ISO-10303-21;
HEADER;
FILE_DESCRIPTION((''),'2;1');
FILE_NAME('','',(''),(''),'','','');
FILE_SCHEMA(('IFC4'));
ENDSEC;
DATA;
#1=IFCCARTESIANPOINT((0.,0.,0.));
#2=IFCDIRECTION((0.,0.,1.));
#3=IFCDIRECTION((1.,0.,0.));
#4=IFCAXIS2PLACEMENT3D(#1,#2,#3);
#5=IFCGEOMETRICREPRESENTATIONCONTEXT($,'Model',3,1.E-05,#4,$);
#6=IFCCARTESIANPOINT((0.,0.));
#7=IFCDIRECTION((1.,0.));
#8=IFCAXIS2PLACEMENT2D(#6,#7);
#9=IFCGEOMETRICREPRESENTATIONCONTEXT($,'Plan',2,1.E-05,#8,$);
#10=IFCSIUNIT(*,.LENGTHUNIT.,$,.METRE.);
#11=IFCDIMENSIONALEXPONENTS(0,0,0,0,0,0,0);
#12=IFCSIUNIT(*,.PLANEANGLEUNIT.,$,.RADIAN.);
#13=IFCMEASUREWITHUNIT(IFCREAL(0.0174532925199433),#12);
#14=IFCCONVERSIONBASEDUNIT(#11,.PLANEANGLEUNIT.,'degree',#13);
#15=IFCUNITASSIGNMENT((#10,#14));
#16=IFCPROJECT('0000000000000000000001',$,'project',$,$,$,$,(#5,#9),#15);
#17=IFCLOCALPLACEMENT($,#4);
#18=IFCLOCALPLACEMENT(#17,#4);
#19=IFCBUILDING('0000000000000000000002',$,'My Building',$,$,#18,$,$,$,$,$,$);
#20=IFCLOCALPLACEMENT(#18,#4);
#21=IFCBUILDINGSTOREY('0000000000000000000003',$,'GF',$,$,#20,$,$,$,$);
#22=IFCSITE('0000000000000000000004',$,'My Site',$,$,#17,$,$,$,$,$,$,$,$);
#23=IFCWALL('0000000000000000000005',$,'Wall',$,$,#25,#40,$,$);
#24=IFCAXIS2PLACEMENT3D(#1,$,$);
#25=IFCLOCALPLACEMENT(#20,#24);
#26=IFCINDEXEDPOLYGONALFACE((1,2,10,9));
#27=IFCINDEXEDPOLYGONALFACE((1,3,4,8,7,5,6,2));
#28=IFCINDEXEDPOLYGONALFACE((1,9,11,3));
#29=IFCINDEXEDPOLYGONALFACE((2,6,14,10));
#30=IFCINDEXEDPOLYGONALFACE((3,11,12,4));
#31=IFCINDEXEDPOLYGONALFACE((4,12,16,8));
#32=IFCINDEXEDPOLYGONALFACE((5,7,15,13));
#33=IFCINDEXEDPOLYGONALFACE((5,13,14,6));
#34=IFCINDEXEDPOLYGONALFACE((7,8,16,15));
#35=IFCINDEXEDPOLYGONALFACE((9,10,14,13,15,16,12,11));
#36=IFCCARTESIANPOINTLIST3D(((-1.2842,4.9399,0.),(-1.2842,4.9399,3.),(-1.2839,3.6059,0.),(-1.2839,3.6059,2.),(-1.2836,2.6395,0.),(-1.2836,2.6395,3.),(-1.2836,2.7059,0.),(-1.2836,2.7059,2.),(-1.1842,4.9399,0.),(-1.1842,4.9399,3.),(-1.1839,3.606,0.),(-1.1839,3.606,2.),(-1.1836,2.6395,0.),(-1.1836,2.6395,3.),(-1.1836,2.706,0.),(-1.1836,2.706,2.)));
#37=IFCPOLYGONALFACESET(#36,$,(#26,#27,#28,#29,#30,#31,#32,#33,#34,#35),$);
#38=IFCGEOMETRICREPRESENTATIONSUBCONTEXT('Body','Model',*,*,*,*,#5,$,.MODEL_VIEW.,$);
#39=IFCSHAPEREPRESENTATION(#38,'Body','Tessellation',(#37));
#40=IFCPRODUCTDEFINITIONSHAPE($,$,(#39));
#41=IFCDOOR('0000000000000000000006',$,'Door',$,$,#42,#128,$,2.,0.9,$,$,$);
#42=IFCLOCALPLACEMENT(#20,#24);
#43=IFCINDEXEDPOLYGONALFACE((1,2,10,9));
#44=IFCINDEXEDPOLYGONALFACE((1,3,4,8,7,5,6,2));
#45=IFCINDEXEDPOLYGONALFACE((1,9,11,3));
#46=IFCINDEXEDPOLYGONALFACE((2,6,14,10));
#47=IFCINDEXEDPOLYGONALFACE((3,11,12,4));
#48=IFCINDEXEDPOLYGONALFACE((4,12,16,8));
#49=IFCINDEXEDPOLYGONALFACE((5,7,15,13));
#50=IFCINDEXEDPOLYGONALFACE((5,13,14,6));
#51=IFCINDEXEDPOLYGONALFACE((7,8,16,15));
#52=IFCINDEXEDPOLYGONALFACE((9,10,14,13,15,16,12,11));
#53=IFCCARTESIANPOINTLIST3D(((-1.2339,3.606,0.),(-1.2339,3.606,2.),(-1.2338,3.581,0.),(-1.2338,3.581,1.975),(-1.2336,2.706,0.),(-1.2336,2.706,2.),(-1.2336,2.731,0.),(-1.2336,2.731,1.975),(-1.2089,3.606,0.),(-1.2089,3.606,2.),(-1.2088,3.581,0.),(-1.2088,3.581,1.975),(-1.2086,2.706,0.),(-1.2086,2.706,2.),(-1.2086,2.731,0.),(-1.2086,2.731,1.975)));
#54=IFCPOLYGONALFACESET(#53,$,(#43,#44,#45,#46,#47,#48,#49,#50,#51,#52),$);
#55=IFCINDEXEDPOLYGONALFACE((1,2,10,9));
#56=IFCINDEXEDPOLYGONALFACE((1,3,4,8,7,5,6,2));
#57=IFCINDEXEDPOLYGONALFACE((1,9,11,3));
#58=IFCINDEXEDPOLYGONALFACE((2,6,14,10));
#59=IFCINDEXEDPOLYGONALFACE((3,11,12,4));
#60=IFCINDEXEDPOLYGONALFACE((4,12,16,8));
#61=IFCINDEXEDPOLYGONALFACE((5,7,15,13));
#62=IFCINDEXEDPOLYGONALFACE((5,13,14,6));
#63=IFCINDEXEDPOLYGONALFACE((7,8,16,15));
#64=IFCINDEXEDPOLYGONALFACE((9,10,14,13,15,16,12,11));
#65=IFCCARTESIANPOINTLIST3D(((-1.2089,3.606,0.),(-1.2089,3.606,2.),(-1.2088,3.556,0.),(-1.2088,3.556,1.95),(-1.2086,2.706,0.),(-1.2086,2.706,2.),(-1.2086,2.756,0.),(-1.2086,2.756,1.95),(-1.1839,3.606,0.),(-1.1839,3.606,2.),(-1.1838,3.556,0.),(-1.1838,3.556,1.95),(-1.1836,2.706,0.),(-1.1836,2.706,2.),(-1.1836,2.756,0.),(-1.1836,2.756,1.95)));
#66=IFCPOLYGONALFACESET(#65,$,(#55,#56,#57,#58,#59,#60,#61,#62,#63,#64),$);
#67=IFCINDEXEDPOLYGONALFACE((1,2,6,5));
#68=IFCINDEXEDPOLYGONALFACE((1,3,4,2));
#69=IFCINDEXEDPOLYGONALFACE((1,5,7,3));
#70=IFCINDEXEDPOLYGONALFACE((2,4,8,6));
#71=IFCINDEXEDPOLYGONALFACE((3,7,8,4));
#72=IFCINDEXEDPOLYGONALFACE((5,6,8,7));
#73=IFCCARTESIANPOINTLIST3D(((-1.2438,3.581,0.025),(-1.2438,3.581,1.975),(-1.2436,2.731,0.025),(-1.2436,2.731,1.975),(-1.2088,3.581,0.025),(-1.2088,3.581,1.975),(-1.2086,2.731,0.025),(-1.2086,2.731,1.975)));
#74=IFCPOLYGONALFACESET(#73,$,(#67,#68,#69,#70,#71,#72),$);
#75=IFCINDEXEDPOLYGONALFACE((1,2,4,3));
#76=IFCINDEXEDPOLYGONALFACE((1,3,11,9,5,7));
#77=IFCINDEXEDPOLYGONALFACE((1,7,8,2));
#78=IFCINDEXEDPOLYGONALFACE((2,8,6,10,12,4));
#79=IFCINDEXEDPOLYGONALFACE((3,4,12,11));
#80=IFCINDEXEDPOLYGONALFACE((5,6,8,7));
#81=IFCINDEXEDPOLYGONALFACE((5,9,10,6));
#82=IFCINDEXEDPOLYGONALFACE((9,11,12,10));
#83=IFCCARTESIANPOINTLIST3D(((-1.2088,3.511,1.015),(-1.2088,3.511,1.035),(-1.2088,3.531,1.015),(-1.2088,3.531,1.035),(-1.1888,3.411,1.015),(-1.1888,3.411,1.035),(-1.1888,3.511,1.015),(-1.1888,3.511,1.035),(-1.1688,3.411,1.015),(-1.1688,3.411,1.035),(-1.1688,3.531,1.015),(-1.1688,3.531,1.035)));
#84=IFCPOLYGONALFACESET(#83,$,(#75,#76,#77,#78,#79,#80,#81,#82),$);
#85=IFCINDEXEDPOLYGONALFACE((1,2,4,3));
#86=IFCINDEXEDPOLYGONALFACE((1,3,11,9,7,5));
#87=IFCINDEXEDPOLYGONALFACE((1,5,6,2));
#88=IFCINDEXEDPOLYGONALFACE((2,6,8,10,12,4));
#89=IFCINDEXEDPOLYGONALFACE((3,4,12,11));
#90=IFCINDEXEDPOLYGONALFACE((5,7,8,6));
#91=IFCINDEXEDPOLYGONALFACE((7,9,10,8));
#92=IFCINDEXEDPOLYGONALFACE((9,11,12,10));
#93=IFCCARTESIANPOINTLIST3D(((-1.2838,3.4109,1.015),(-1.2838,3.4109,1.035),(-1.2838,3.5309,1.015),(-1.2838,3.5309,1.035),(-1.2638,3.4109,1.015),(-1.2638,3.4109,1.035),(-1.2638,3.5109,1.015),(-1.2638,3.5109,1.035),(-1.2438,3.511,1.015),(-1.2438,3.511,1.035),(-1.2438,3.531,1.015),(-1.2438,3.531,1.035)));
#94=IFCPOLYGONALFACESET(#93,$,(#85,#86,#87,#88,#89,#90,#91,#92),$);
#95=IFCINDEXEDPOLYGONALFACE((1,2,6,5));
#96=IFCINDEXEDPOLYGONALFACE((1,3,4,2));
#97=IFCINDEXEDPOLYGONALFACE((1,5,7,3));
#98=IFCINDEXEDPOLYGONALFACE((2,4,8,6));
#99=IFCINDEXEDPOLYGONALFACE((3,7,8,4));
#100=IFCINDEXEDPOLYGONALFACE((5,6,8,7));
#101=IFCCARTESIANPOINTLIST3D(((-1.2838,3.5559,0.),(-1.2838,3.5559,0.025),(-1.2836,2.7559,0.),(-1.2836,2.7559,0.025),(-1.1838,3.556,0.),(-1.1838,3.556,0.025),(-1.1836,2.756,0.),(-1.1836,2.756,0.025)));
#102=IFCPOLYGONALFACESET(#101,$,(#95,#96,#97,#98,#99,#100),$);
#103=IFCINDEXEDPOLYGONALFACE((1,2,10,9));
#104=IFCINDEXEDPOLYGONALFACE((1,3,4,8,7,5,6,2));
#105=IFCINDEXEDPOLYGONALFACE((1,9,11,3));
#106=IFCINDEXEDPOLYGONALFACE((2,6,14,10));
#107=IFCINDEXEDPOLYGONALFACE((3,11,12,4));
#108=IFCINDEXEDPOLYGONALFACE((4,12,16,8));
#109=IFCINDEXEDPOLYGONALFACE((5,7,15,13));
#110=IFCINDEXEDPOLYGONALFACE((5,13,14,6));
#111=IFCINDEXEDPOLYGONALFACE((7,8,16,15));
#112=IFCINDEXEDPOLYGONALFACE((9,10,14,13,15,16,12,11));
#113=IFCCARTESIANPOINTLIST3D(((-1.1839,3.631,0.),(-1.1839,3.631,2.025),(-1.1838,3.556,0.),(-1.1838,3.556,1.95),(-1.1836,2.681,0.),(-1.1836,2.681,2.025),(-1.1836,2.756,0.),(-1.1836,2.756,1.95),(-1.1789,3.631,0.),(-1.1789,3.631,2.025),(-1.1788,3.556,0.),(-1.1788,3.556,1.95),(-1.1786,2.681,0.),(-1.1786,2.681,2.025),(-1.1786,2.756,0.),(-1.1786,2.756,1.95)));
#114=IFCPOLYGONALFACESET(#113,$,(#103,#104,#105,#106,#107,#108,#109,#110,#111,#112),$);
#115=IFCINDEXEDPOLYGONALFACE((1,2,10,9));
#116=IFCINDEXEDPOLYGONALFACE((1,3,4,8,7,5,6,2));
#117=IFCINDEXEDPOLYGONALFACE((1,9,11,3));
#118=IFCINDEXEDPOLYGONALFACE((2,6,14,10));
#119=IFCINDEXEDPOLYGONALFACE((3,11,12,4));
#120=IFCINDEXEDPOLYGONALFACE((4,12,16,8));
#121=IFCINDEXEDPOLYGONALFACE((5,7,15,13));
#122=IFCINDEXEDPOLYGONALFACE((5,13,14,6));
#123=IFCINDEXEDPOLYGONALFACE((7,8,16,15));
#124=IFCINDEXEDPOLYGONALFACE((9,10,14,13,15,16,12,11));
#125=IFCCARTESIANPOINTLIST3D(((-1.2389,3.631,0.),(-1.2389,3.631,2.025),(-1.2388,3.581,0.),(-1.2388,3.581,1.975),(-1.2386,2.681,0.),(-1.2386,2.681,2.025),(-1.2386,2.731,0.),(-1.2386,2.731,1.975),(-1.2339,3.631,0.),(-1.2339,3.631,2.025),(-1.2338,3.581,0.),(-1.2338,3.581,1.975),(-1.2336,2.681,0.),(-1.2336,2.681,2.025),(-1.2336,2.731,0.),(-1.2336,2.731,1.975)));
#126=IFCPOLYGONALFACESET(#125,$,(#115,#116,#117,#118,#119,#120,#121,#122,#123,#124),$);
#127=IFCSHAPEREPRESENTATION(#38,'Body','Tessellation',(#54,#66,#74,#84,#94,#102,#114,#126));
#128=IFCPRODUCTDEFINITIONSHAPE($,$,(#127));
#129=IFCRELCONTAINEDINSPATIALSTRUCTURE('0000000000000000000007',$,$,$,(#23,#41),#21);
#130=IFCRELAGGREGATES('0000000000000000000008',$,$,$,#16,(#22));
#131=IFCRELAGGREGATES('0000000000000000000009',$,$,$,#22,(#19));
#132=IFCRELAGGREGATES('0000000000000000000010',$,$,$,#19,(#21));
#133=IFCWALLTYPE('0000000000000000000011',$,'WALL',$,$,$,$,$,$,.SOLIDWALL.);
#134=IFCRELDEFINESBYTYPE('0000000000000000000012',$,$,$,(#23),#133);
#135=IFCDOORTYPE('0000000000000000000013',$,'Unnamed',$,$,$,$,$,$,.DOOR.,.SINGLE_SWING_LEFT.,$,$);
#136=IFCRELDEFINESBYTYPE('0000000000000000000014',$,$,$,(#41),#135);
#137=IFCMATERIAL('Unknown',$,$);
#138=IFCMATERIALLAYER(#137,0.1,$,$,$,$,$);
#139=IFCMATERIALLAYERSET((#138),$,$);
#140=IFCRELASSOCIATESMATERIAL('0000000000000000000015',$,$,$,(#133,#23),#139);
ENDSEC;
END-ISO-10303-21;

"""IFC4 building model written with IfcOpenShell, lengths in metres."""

from ifc_helpers import new_model, entity, si_unit, converted_unit, frame, origin_with_axes, origin_2d_with_axis, place, context, subcontext, project, spatial, line, indexed_curve, outline, extrude, shape, source, transform, mapped, material, layer, layer_set, layer_usage, type_object, type_shapes, element, fill, save


model = new_model("IFC4")

# Units and contexts
model_context = context("Model", 3, precision=1e-05, world=origin_with_axes())
plan_context = context("Plan", 2, precision=1e-05, world=origin_2d_with_axis())
body_context_1 = subcontext(model_context, "Body", "Model", "MODEL_VIEW")
body_context_2 = subcontext(plan_context, "Body", "Plan", "PLAN_VIEW")
ifc_project = project(units=[si_unit("LENGTHUNIT", "METRE"), converted_unit("PLANEANGLEUNIT", "degree", entity("IfcReal", 0.0174532925199433), si_unit("PLANEANGLEUNIT", "RADIAN"), dimensions=[0, 0, 0, 0, 0, 0, 0])], contexts=[model_context, plan_context])

# Site, building, storey
site_placement = place(None, origin_with_axes())
site = spatial("IfcSite", under=ifc_project, at=site_placement, Name="My Site")
building_placement = place(site_placement, origin_with_axes())
building = spatial("IfcBuilding", under=site, at=building_placement, Name="My Building")
storey_placement = place(building_placement, origin_with_axes())
storey = spatial("IfcBuildingStorey", under=building, at=storey_placement, Name="GF")

# Shared definitions
ifc_material_1 = material(Name="Unknown")

# Shared definitions
ifc_layer_1 = layer(ifc_material_1, 0.1)
ifc_layer_set_1 = layer_set([ifc_layer_1])
wall_type = type_object("IfcWallType", Name="WALL", PredefinedType="SOLIDWALL", material=ifc_layer_set_1)
shared_shape_1 = source(origin_with_axes(), body_context_1, "Body", "SweptSolid", [
    extrude(outline(indexed_curve([(0.0, 0.0), (0.9, 0.0), (0.9, 2.0), (0.0, 2.0)], segments=[line(1, 2, 3, 4, 1)])), frame((0.0, -0.6, 0.0), z_axis=(0.0, -1.0, 0.0), x_axis=(1.0, 0.0, 0.0)), (0.0, 0.0, -1.0), 1.2),
])
door_type = type_object("IfcDoorType", Name="Unnamed", OperationType="SINGLE_SWING_LEFT", PredefinedType="DOOR")
shared_shape_2 = source(origin_with_axes(), body_context_1, "Body", "SweptSolid", [
    extrude(outline(indexed_curve([(0.0, 0.0), (0.0, 2.0), (0.9, 2.0), (0.9, 0.0), (0.875, 0.0), (0.875, 1.975), (0.025, 1.975), (0.025, 0.0)], segments=[line(1, 2, 3, 4, 5, 6, 7, 8, 1)])), frame((0.0, 0.025, 0.0), z_axis=(0.0, -1.0, 0.0), x_axis=(1.0, 0.0, 0.0)), (0.0, 0.0, -1.0), 0.025),
    extrude(outline(indexed_curve([(0.0, 0.0), (0.0, 2.0), (0.9, 2.0), (0.9, 0.0), (0.85, 0.0), (0.85, 1.95), (0.05, 1.95), (0.05, 0.0)], segments=[line(1, 2, 3, 4, 5, 6, 7, 8, 1)])), frame((0.0, 0.0, 0.0), z_axis=(0.0, -1.0, 0.0), x_axis=(1.0, 0.0, 0.0)), (0.0, 0.0, -1.0), 0.025),
    extrude(outline(indexed_curve([(0.0, 0.0), (0.85, 0.0), (0.85, 0.035), (0.0, 0.035)], segments=[line(1, 2, 3, 4, 1)])), frame((0.025, 0.025, 0.025), z_axis=(0.0, 0.0, 1.0), x_axis=(1.0, 0.0, 0.0)), (0.0, 0.0, 1.0), 1.95),
    extrude(outline(indexed_curve([(0.0, 0.0), (0.0, -0.04), (-0.12, -0.04), (-0.12, -0.02), (-0.02, -0.02), (-0.02, 0.0)], segments=[line(1, 2, 3, 4, 5, 6, 1)])), frame((0.825, 0.025, 1.015), z_axis=(0.0, 0.0, 1.0), x_axis=(1.0, 0.0, 0.0)), (0.0, 0.0, 1.0), 0.02),
    extrude(outline(indexed_curve([(0.0, 0.0), (0.0, 0.04), (-0.12, 0.04), (-0.12, 0.02), (-0.02, 0.02), (-0.02, 0.0)], segments=[line(1, 2, 3, 4, 5, 6, 1)])), frame((0.825, 0.06, 1.015), z_axis=(0.0, 0.0, 1.0), x_axis=(1.0, 0.0, 0.0)), (0.0, 0.0, 1.0), 0.02),
    extrude(outline(indexed_curve([(0.0, 0.0), (0.8, 0.0), (0.8, 0.1), (0.0, 0.1)], segments=[line(1, 2, 3, 4, 1)])), frame((0.05, 0.0, 0.0), z_axis=(0.0, 0.0, 1.0), x_axis=(1.0, 0.0, 0.0)), (0.0, 0.0, 1.0), 0.025),
    extrude(outline(indexed_curve([(0.0, 0.0), (0.0, 2.025), (0.95, 2.025), (0.95, 0.0), (0.875, 0.0), (0.875, 1.95), (0.075, 1.95), (0.075, 0.0)], segments=[line(1, 2, 3, 4, 5, 6, 7, 8, 1)])), frame((-0.025, -0.005, 0.0), z_axis=(0.0, -1.0, 0.0), x_axis=(1.0, 0.0, 0.0)), (0.0, 0.0, -1.0), 0.005),
    extrude(outline(indexed_curve([(0.0, 0.0), (0.0, 2.025), (0.95, 2.025), (0.95, 0.0), (0.9, 0.0), (0.9, 1.975), (0.05, 1.975), (0.05, 0.0)], segments=[line(1, 2, 3, 4, 5, 6, 7, 8, 1)])), frame((-0.025, 0.05, 0.0), z_axis=(0.0, -1.0, 0.0), x_axis=(1.0, 0.0, 0.0)), (0.0, 0.0, -1.0), 0.005),
])
shared_shape_3 = source(origin_with_axes(), body_context_2, "Body", "Curve2D", [
    entity("IfcIndexedPolyCurve", entity("IfcCartesianPointList2D", [[0.0, 0.0], [0.0, 0.05], [0.025, 0.05], [0.025, 0.025], [0.05, 0.025], [0.05, 0.0]]), [entity("IfcLineIndex", [1, 2, 3, 4, 5, 6, 1])]),
    entity("IfcIndexedPolyCurve", entity("IfcCartesianPointList2D", [[0.9, 0.0], [0.9, 0.05], [0.875, 0.05], [0.875, 0.025], [0.85, 0.025], [0.85, 0.0]]), [entity("IfcLineIndex", [1, 2, 3, 4, 5, 6, 1])]),
    entity("IfcTrimmedCurve", entity("IfcEllipse", entity("IfcAxis2Placement2D", entity("IfcCartesianPoint", [0.06, 0.05]), entity("IfcDirection", [1.0, 0.0])), 0.815, 0.85), [entity("IfcCartesianPoint", [0.875, 0.05])], [entity("IfcCartesianPoint", [0.06, 0.9])], True, "CARTESIAN"),
    entity("IfcIndexedPolyCurve", entity("IfcCartesianPointList2D", [[0.025, 0.05], [0.06, 0.05], [0.06, 0.9], [0.025, 0.9]]), [entity("IfcLineIndex", [1, 2, 3, 4, 1])]),
])
type_shapes(door_type, [shared_shape_2, shared_shape_3])

# Wall, opening, door
ifc_layer_usage_1 = layer_usage(ifc_layer_set_1, "AXIS2", "POSITIVE", 0.0)
wall_1_placement = place(storey_placement, frame((-1.1836, 2.6395, 0.0), z_axis=(0.0, 0.0, 1.0), x_axis=(-0.000265, 1.0, 0.0)))
wall_1 = element("IfcWall", 1, at=wall_1_placement, inside=storey, type_object=wall_type, material=ifc_layer_usage_1, Name="Wall", context=body_context_1, shape_type="SweptSolid", body=[
    extrude(outline(indexed_curve([(0.0, 0.0), (0.0, 0.1), (2.3004, 0.1), (2.3004, 0.0)], segments=[line(1, 2, 3, 4, 1)])), origin_with_axes(), (0.0, 0.0, 1.0), 3.0),
])
opening_1_placement = place(wall_1_placement, frame((0.0664, 0.0, 0.0), z_axis=(0.0, 0.0, 1.0), x_axis=(1.0, 0.0, 0.0)))
opening_1 = element("IfcOpeningElement", 2, at=opening_1_placement, cuts=wall_1, PredefinedType="OPENING", context=body_context_1, shape_type="MappedRepresentation", body=[
    mapped(shared_shape_1, transform((0.0, 0.0, 0.0), x_axis=(1.0, 0.0, 0.0), y_axis=(0.0, 1.0, 0.0), z_axis=(0.0, 0.0, 1.0), scale=1.0)),
])
door_1_placement = place(opening_1_placement, frame((0.0, 0.0, 0.0), z_axis=(0.0, 0.0, 1.0), x_axis=(1.0, 0.0, 0.0)))
door_1 = element("IfcDoor", 3, at=door_1_placement, inside=storey, type_object=door_type, Name="Door", OverallHeight=2.0, OverallWidth=0.9, shapes=[
    shape(body_context_1, "Body", "MappedRepresentation", [mapped(shared_shape_2, transform((0.0, 0.0, 0.0), x_axis=(1.0, 0.0, 0.0), y_axis=(0.0, 1.0, 0.0), z_axis=(0.0, 0.0, 1.0), scale=1.0))]),
    shape(body_context_2, "Body", "MappedRepresentation", [mapped(shared_shape_3, transform((0.0, 0.0, 0.0), x_axis=(1.0, 0.0, 0.0), y_axis=(0.0, 1.0, 0.0), z_axis=(0.0, 0.0, 1.0), scale=1.0))]),
])
fill(opening_1, door_1)

save(model, "model.ifc")
